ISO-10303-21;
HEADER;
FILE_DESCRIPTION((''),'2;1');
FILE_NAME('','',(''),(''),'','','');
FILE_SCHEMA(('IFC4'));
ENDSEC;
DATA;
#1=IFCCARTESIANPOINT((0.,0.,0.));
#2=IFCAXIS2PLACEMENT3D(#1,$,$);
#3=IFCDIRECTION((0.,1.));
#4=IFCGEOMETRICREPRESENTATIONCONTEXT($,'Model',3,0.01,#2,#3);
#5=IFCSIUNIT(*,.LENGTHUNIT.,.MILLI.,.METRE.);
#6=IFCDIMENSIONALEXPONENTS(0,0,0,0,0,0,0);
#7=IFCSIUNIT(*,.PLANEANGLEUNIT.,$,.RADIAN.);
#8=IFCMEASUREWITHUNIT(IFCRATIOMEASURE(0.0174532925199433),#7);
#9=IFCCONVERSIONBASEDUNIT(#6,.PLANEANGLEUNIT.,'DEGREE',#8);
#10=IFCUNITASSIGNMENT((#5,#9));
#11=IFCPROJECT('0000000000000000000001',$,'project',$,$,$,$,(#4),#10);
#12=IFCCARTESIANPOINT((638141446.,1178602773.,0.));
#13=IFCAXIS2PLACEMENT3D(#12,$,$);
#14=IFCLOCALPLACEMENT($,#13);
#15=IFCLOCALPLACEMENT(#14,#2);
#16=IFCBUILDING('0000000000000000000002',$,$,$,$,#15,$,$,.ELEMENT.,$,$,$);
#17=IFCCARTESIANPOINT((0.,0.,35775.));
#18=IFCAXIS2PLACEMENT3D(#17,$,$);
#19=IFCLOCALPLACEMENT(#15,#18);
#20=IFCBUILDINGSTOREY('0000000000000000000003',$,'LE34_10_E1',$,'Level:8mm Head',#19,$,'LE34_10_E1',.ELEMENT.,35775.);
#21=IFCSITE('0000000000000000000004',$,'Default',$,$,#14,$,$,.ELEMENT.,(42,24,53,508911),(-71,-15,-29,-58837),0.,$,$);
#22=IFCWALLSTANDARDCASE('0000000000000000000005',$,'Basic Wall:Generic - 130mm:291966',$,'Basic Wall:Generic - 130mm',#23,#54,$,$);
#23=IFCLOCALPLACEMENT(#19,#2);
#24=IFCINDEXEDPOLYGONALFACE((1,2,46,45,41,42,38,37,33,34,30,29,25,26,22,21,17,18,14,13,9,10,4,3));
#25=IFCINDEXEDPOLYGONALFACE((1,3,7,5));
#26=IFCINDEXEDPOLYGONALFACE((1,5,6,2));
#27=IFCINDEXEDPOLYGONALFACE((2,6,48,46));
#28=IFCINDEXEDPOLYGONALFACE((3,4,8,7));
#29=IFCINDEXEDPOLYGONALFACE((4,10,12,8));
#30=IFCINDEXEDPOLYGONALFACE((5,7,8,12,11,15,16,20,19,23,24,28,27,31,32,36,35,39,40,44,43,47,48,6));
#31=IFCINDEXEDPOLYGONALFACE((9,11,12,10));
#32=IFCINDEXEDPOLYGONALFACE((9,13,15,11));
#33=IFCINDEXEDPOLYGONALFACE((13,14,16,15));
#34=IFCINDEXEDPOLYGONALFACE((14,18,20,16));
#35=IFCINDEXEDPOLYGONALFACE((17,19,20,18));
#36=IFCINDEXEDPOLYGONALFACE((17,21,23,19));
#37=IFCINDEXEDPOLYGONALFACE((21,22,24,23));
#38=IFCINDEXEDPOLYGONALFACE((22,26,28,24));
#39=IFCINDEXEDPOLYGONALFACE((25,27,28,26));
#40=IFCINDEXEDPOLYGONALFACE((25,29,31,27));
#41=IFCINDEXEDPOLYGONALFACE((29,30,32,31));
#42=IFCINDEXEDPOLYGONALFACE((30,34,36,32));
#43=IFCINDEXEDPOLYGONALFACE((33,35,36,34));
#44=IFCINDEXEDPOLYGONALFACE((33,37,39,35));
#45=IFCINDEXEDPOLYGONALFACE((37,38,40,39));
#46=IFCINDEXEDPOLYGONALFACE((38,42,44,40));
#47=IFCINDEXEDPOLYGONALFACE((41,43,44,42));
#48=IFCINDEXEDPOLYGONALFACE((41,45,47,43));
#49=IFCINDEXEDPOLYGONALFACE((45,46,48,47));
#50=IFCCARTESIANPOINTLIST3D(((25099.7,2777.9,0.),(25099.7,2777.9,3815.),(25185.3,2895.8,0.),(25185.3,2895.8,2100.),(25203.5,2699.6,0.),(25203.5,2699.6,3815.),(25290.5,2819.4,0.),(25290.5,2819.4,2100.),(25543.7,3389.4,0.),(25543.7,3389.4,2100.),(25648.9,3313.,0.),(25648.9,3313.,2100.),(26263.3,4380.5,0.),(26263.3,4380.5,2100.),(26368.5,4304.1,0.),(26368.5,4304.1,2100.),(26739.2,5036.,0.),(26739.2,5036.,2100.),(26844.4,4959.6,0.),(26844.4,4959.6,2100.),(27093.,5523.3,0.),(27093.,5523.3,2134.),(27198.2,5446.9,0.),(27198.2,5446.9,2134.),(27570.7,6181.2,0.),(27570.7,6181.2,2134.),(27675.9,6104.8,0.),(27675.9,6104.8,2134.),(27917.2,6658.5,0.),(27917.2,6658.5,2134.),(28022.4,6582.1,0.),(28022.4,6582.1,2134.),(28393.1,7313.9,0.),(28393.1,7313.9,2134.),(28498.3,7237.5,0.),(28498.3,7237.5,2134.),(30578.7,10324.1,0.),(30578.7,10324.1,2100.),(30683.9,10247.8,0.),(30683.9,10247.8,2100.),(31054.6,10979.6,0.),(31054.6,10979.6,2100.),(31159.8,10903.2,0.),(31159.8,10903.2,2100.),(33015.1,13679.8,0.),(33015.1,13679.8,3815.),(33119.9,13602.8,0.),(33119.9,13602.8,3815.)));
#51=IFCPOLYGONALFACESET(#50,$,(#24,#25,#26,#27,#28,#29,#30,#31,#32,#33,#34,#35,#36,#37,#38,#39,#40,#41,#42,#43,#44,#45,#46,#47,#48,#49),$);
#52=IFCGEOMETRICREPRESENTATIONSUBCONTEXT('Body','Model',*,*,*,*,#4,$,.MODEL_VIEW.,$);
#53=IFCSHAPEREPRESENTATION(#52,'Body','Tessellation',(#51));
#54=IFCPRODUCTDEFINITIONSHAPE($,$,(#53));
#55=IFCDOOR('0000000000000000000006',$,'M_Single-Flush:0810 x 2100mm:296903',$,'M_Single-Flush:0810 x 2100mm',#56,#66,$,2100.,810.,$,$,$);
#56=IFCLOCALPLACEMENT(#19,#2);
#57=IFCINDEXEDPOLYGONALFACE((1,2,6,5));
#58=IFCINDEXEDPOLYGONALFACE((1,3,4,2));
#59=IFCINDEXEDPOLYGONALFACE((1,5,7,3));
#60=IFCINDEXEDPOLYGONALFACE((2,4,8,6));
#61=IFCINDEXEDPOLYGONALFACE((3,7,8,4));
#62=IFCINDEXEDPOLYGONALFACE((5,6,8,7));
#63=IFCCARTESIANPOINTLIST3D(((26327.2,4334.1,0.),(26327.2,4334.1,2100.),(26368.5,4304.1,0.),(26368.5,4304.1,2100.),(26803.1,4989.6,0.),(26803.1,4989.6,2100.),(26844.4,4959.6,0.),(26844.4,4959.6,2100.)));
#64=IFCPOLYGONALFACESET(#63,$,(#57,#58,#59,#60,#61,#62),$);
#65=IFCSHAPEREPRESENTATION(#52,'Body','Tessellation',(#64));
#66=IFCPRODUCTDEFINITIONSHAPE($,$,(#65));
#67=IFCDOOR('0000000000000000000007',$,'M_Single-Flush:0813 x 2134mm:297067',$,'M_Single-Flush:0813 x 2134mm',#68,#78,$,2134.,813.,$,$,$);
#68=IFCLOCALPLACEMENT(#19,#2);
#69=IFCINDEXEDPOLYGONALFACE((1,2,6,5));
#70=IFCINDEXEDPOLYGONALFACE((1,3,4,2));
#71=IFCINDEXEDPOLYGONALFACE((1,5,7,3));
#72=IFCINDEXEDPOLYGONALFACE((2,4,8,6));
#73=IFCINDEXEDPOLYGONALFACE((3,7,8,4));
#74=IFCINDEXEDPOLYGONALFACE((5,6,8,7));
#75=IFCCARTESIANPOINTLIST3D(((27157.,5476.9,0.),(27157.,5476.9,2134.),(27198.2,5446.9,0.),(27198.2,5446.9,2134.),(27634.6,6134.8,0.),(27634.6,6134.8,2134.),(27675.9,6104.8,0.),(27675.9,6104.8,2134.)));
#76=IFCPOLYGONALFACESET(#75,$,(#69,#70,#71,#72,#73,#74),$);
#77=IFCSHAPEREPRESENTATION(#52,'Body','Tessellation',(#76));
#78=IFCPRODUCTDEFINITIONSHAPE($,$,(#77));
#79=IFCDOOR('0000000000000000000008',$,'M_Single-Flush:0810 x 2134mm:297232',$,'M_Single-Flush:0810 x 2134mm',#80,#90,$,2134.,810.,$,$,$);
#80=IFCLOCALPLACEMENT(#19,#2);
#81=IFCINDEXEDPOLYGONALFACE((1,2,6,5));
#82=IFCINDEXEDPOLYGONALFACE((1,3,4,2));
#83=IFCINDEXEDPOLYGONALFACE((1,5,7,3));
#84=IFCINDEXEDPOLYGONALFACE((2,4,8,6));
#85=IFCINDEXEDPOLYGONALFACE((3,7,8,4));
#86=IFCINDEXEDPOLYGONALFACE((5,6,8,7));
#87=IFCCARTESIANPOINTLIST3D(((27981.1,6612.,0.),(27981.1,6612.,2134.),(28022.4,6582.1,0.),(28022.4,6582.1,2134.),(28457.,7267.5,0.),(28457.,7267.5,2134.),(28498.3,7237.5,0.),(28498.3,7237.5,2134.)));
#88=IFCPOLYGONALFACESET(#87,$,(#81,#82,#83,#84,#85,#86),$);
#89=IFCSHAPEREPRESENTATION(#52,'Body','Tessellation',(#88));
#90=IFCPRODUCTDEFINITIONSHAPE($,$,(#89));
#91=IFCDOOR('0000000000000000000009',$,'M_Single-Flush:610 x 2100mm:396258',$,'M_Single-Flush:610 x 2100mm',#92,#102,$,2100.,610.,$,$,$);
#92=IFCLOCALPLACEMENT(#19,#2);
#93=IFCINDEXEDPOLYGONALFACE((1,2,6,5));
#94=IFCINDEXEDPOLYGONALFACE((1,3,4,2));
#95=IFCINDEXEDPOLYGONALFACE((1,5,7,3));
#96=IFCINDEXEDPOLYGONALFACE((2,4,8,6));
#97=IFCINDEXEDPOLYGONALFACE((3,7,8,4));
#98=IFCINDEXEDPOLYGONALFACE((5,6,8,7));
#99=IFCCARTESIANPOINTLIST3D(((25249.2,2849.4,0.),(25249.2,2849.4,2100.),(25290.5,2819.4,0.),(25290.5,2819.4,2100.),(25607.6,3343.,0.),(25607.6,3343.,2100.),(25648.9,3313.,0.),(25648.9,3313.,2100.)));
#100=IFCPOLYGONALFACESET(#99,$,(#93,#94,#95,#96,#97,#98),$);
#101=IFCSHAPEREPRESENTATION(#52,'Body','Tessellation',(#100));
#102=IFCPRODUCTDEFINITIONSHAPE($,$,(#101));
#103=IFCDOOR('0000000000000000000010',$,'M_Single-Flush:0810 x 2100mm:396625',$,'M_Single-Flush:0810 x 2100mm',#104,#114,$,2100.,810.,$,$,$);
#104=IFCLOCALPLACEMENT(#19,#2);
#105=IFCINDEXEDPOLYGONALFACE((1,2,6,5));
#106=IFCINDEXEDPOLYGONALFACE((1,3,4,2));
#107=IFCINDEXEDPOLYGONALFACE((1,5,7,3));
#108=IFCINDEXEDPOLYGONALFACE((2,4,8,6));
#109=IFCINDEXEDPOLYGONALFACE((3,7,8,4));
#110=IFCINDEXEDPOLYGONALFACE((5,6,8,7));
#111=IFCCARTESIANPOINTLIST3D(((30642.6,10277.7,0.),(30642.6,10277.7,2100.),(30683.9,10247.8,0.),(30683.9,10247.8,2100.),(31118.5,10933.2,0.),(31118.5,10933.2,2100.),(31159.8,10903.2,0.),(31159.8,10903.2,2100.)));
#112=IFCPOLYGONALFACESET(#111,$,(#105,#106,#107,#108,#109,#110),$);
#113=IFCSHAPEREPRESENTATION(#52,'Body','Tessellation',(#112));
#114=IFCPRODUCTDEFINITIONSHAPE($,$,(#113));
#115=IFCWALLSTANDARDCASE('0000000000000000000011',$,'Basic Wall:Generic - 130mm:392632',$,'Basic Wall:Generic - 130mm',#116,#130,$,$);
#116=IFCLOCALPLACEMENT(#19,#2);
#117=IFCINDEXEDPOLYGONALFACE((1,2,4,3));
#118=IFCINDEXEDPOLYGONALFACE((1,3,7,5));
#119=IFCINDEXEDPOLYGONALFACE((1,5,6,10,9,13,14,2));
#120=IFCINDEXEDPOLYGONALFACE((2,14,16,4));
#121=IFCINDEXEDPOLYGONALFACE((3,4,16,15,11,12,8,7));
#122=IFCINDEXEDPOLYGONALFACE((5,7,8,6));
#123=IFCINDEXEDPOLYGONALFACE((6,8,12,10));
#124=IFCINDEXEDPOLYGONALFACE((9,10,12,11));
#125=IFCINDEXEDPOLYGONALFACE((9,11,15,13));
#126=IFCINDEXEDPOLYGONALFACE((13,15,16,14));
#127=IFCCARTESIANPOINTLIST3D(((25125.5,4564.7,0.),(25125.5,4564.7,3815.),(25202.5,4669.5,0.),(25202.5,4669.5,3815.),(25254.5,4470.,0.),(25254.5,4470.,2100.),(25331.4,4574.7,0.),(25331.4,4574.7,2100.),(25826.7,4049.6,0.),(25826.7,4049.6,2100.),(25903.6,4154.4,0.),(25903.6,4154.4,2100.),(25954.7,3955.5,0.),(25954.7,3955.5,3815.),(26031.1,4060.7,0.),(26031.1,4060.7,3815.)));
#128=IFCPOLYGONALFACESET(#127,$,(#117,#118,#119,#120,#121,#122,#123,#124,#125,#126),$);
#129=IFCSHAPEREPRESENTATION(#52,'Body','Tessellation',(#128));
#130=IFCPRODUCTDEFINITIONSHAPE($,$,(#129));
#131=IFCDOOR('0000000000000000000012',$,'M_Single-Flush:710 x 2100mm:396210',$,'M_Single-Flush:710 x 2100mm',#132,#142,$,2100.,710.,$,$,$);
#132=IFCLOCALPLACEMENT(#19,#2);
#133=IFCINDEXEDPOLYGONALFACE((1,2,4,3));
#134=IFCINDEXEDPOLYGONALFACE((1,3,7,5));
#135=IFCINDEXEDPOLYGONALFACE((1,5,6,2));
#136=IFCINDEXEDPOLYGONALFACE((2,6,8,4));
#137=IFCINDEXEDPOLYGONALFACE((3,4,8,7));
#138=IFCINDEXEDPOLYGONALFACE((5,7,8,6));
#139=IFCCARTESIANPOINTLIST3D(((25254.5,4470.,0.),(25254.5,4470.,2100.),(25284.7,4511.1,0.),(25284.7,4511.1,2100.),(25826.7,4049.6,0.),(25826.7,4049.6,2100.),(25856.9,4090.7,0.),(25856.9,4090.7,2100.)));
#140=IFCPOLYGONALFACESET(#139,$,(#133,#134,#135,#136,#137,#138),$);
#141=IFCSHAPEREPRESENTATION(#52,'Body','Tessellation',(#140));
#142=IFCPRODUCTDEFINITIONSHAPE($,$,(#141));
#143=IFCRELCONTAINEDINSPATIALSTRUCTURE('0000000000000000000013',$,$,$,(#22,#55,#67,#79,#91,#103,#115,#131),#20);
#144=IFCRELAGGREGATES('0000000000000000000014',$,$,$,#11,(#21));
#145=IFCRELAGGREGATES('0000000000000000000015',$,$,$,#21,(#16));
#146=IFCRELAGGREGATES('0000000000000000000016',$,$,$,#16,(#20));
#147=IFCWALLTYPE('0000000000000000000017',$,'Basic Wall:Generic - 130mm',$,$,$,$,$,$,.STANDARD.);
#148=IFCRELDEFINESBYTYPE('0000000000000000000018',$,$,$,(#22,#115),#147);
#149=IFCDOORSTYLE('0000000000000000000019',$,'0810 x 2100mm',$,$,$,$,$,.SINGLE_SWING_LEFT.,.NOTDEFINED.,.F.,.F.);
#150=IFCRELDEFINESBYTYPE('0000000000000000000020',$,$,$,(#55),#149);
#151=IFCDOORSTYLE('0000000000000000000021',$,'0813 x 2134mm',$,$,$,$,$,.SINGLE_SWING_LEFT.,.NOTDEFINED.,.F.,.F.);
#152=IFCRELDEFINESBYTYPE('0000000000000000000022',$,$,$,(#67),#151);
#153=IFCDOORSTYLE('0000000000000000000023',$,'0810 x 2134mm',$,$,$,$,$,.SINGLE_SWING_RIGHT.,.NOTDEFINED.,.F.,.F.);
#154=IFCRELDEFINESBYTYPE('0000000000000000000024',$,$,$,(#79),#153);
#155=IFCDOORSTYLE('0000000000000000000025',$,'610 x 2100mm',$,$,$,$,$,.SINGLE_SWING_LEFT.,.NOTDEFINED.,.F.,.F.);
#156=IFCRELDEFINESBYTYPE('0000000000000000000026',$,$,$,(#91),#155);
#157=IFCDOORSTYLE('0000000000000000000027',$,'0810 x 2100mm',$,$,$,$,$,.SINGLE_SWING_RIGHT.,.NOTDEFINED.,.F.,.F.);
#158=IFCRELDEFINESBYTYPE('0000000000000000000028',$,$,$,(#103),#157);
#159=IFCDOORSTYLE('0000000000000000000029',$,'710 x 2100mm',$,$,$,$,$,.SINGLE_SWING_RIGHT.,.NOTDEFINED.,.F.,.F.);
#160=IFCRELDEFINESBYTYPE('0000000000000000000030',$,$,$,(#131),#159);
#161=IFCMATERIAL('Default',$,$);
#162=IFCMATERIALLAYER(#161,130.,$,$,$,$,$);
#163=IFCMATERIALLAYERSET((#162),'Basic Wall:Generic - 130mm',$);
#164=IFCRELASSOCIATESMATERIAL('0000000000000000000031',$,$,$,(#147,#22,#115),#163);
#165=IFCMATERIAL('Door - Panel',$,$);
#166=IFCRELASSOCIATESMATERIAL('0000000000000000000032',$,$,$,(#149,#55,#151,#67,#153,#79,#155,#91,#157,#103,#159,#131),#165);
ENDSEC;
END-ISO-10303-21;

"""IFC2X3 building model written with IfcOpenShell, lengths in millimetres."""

from ifc_helpers import new_model, entity, si_unit, converted_unit, direction, frame, frame_2d, origin, place, context, subcontext, project, spatial, polyline, rectangle, outline, extrude, source, transform, mapped, material, layer, layer_set, layer_usage, type_object, type_shapes, element, fill, save


model = new_model("IFC2X3")

# Units and contexts
model_context = context("Model", 3, precision=0.01, world=origin(), true_north=direction((0.0, 1.0)))
body_context = subcontext(model_context, "Body", "Model", "MODEL_VIEW")
ifc_project = project(units=[si_unit("LENGTHUNIT", "METRE", prefix="MILLI"), converted_unit("PLANEANGLEUNIT", "DEGREE", entity("IfcRatioMeasure", 0.0174532925199433), si_unit("PLANEANGLEUNIT", "RADIAN"), dimensions=[0, 0, 0, 0, 0, 0, 0])], contexts=[model_context])

# Site, building, storey
site_placement = place(None, frame((638141446.0, 1178602773.0, 0.0)))
site = spatial("IfcSite", under=ifc_project, at=site_placement, Name="Default", CompositionType="ELEMENT", RefLatitude=(42, 24, 53, 508911), RefLongitude=(-71, -15, -29, -58837), RefElevation=0.0)
building_placement = place(site_placement, origin())
building = spatial("IfcBuilding", under=site, at=building_placement, CompositionType="ELEMENT")
storey_placement = place(building_placement, frame((0.0, 0.0, 35775.0)))
storey = spatial("IfcBuildingStorey", under=building, at=storey_placement, Name="LE34_10_E1", ObjectType="Level:8mm Head", LongName="LE34_10_E1", CompositionType="ELEMENT", Elevation=35775.0)

# Shared definitions
ifc_material_1 = material(Name="Default")

# Wall, openings, doors
ifc_layer_1 = layer(ifc_material_1, 130.0)
ifc_layer_set_1 = layer_set([ifc_layer_1], Name="Basic Wall:Generic - 130mm")
ifc_layer_usage_1 = layer_usage(ifc_layer_set_1, "AXIS2", "NEGATIVE", 65.0)
wall_type_1 = type_object("IfcWallType", Name="Basic Wall:Generic - 130mm", PredefinedType="STANDARD", material=ifc_layer_set_1)
wall_1_placement = place(storey_placement, frame((25150.9, 2737.7, 0.0), z_axis=(0.0, 0.0, 1.0), x_axis=(0.587528, 0.809204, 0.0)))
wall_1 = element("IfcWallStandardCase", 1, at=wall_1_placement, inside=storey, type_object=wall_type_1, material=ifc_layer_usage_1, Name="Basic Wall:Generic - 130mm:291966", ObjectType="Basic Wall:Generic - 130mm", context=body_context, shape_type="SweptSolid", body=[
    extrude(outline(polyline([(0.0, -65.0), (935.1, -65.0), (1195.1, -65.0), (3014.7, -65.0), (3134.7, -65.0), (4466.6, -65.0), (4606.6, -65.0), (13474.0, -65.0), (13474.8, 65.0), (10597.9, 65.0), (10477.9, 65.0), (1587.7, 65.0), (1457.7, 65.0), (2.4, 65.0), (0.0, -65.0)])), origin(), (0.0, 0.0, 1.0), 3815.0),
])
opening_1_placement = place(wall_1_placement, frame((2792.9, 65.0, 0.0)))
opening_1 = element("IfcOpeningElement", 2, at=opening_1_placement, cuts=wall_1, ObjectType="Opening", context=body_context, shape_type="SweptSolid", body=[
    extrude(rectangle(XDim=810.0, YDim=2100.0, at=frame_2d((1050.0, 405.0), x_axis=(0.0, -1.0))), frame((0.0, 0.0, 0.0), z_axis=(0.0, -1.0, 0.0), x_axis=(0.0, 0.0, 1.0)), (0.0, 0.0, 1.0), 130.0),
])
opening_2_placement = place(wall_1_placement, frame((4208.2, 65.0, 0.0)))
opening_2 = element("IfcOpeningElement", 3, at=opening_2_placement, cuts=wall_1, ObjectType="Opening", context=body_context, shape_type="SweptSolid", body=[
    extrude(rectangle(XDim=813.0, YDim=2134.0, at=frame_2d((1067.0, 406.5), x_axis=(0.0, -1.0))), frame((0.0, 0.0, 0.0), z_axis=(0.0, -1.0, 0.0), x_axis=(0.0, 0.0, 1.0)), (0.0, 0.0, 1.0), 130.0),
])
opening_3_placement = place(wall_1_placement, frame((5607.9, 65.0, 0.0)))
opening_3 = element("IfcOpeningElement", 4, at=opening_3_placement, cuts=wall_1, ObjectType="Opening", context=body_context, shape_type="SweptSolid", body=[
    extrude(rectangle(XDim=810.0, YDim=2134.0, at=frame_2d((1067.0, 405.0), x_axis=(0.0, 1.0))), frame((0.0, 0.0, 0.0), z_axis=(0.0, -1.0, 0.0), x_axis=(0.0, 0.0, 1.0)), (0.0, 0.0, 1.0), 130.0),
])
opening_4_placement = place(wall_1_placement, frame((758.1, 65.0, 0.0)))
opening_4 = element("IfcOpeningElement", 5, at=opening_4_placement, cuts=wall_1, ObjectType="Opening", context=body_context, shape_type="SweptSolid", body=[
    extrude(rectangle(XDim=610.0, YDim=2100.0, at=frame_2d((1050.0, 305.0), x_axis=(0.0, -1.0))), frame((0.0, 0.0, 0.0), z_axis=(0.0, -1.0, 0.0), x_axis=(0.0, 0.0, 1.0)), (0.0, 0.0, 1.0), 130.0),
])
opening_5_placement = place(wall_1_placement, frame((10137.9, 65.0, 0.0)))
opening_5 = element("IfcOpeningElement", 6, at=opening_5_placement, cuts=wall_1, ObjectType="Opening", context=body_context, shape_type="SweptSolid", body=[
    extrude(rectangle(XDim=810.0, YDim=2100.0, at=frame_2d((1050.0, 405.0), x_axis=(0.0, 1.0))), frame((0.0, 0.0, 0.0), z_axis=(0.0, -1.0, 0.0), x_axis=(0.0, 0.0, 1.0)), (0.0, 0.0, 1.0), 130.0),
])
ifc_material_2 = material(Name="Door - Panel")
door_style_1 = type_object("IfcDoorStyle", Name="0810 x 2100mm", ConstructionType="NOTDEFINED", OperationType="SINGLE_SWING_LEFT", ParameterTakesPrecedence=False, Sizeable=False, material=ifc_material_2)
shared_shape_1 = source(origin(), body_context, "Body", "SweptSolid", [
    extrude(rectangle(XDim=810.0, YDim=51.0, at=frame_2d((0.0, 0.0), x_axis=(1.0, 0.0))), frame((405.0, 104.5, 0.0)), (0.0, 0.0, 1.0), 2100.0),
])
type_shapes(door_style_1, [shared_shape_1])
door_1_placement = place(opening_1_placement, frame((0.0, 0.0, 0.0), z_axis=(0.0, 0.0, 1.0), x_axis=(-1.0, 0.0, 0.0)))
door_1 = element("IfcDoor", 7, at=door_1_placement, inside=storey, type_object=door_style_1, material=ifc_material_2, Name="M_Single-Flush:0810 x 2100mm:296903", ObjectType="M_Single-Flush:0810 x 2100mm", OverallHeight=2100.0, OverallWidth=810.0, context=body_context, shape_type="MappedRepresentation", body=[
    mapped(shared_shape_1, transform((0.0, 0.0, 0.0), scale=1.0)),
])
fill(opening_1, door_1)
door_style_2 = type_object("IfcDoorStyle", Name="0813 x 2134mm", ConstructionType="NOTDEFINED", OperationType="SINGLE_SWING_LEFT", ParameterTakesPrecedence=False, Sizeable=False, material=ifc_material_2)
shared_shape_2 = source(origin(), body_context, "Body", "SweptSolid", [
    extrude(rectangle(XDim=813.0, YDim=51.0, at=frame_2d((0.0, 0.0), x_axis=(1.0, 0.0))), frame((406.5, 104.5, 0.0)), (0.0, 0.0, 1.0), 2134.0),
])
type_shapes(door_style_2, [shared_shape_2])
door_2_placement = place(opening_2_placement, frame((0.0, 0.0, 0.0), z_axis=(0.0, 0.0, 1.0), x_axis=(-1.0, 0.0, 0.0)))
door_2 = element("IfcDoor", 8, at=door_2_placement, inside=storey, type_object=door_style_2, material=ifc_material_2, Name="M_Single-Flush:0813 x 2134mm:297067", ObjectType="M_Single-Flush:0813 x 2134mm", OverallHeight=2134.0, OverallWidth=813.0, context=body_context, shape_type="MappedRepresentation", body=[
    mapped(shared_shape_2, transform((0.0, 0.0, 0.0), scale=1.0)),
])
fill(opening_2, door_2)
door_style_3 = type_object("IfcDoorStyle", Name="0810 x 2134mm", ConstructionType="NOTDEFINED", OperationType="SINGLE_SWING_RIGHT", ParameterTakesPrecedence=False, Sizeable=False, material=ifc_material_2)
shared_shape_3 = source(origin(), body_context, "Body", "SweptSolid", [
    extrude(rectangle(XDim=51.0, YDim=810.0, at=frame_2d((0.0, 0.0), x_axis=(1.0, 0.0))), frame((405.0, 104.5, 0.0), z_axis=(0.0, 0.0, 1.0), x_axis=(0.0, 1.0, 0.0)), (0.0, 0.0, 1.0), 2134.0),
])
type_shapes(door_style_3, [shared_shape_3])
door_3_placement = place(opening_3_placement, frame((0.0, 0.0, 0.0), z_axis=(0.0, 0.0, 1.0), x_axis=(-1.0, 0.0, 0.0)))
door_3 = element("IfcDoor", 9, at=door_3_placement, inside=storey, type_object=door_style_3, material=ifc_material_2, Name="M_Single-Flush:0810 x 2134mm:297232", ObjectType="M_Single-Flush:0810 x 2134mm", OverallHeight=2134.0, OverallWidth=810.0, context=body_context, shape_type="MappedRepresentation", body=[
    mapped(shared_shape_3, transform((0.0, 0.0, 0.0), scale=1.0)),
])
fill(opening_3, door_3)
door_style_4 = type_object("IfcDoorStyle", Name="610 x 2100mm", ConstructionType="NOTDEFINED", OperationType="SINGLE_SWING_LEFT", ParameterTakesPrecedence=False, Sizeable=False, material=ifc_material_2)
shared_shape_4 = source(origin(), body_context, "Body", "SweptSolid", [
    extrude(rectangle(XDim=610.0, YDim=51.0, at=frame_2d((0.0, 0.0), x_axis=(1.0, 0.0))), frame((305.0, 104.5, 0.0)), (0.0, 0.0, 1.0), 2100.0),
])
type_shapes(door_style_4, [shared_shape_4])
door_4_placement = place(opening_4_placement, frame((0.0, 0.0, 0.0), z_axis=(0.0, 0.0, 1.0), x_axis=(-1.0, 0.0, 0.0)))
door_4 = element("IfcDoor", 10, at=door_4_placement, inside=storey, type_object=door_style_4, material=ifc_material_2, Name="M_Single-Flush:610 x 2100mm:396258", ObjectType="M_Single-Flush:610 x 2100mm", OverallHeight=2100.0, OverallWidth=610.0, context=body_context, shape_type="MappedRepresentation", body=[
    mapped(shared_shape_4, transform((0.0, 0.0, 0.0), scale=1.0)),
])
fill(opening_4, door_4)
door_style_5 = type_object("IfcDoorStyle", Name="0810 x 2100mm", ConstructionType="NOTDEFINED", OperationType="SINGLE_SWING_RIGHT", ParameterTakesPrecedence=False, Sizeable=False, material=ifc_material_2)
shared_shape_5 = source(origin(), body_context, "Body", "SweptSolid", [
    extrude(rectangle(XDim=51.0, YDim=810.0, at=frame_2d((0.0, 0.0), x_axis=(1.0, 0.0))), frame((405.0, 104.5, 0.0), z_axis=(0.0, 0.0, 1.0), x_axis=(0.0, 1.0, 0.0)), (0.0, 0.0, 1.0), 2100.0),
])
type_shapes(door_style_5, [shared_shape_5])
door_5_placement = place(opening_5_placement, frame((0.0, 0.0, 0.0), z_axis=(0.0, 0.0, 1.0), x_axis=(-1.0, 0.0, 0.0)))
door_5 = element("IfcDoor", 11, at=door_5_placement, inside=storey, type_object=door_style_5, material=ifc_material_2, Name="M_Single-Flush:0810 x 2100mm:396625", ObjectType="M_Single-Flush:0810 x 2100mm", OverallHeight=2100.0, OverallWidth=810.0, context=body_context, shape_type="MappedRepresentation", body=[
    mapped(shared_shape_5, transform((0.0, 0.0, 0.0), scale=1.0)),
])
fill(opening_5, door_5)

# Wall, opening, door
ifc_layer_usage_2 = layer_usage(ifc_layer_set_1, "AXIS2", "NEGATIVE", 65.0)
wall_2_placement = place(storey_placement, frame((25164.0, 4617.1, 0.0), z_axis=(0.0, 0.0, 1.0), x_axis=(0.805916, -0.592029, 0.0)))
wall_2 = element("IfcWallStandardCase", 12, at=wall_2_placement, inside=storey, type_object=wall_type_1, material=ifc_layer_usage_2, Name="Basic Wall:Generic - 130mm:392632", ObjectType="Basic Wall:Generic - 130mm", context=body_context, shape_type="SweptSolid", body=[
    extrude(outline(polyline([(0.0, -65.0), (1028.9, -65.0), (1028.2, 65.0), (0.0, 65.0), (0.0, -65.0)])), origin(), (0.0, 0.0, 1.0), 3815.0),
])
opening_6_placement = place(wall_2_placement, frame((870.0, 65.0, 0.0)))
opening_6 = element("IfcOpeningElement", 13, at=opening_6_placement, cuts=wall_2, ObjectType="Opening", context=body_context, shape_type="SweptSolid", body=[
    extrude(rectangle(XDim=710.0, YDim=2100.0, at=frame_2d((1050.0, 355.0), x_axis=(0.0, 1.0))), frame((0.0, 0.0, 0.0), z_axis=(0.0, -1.0, 0.0), x_axis=(0.0, 0.0, 1.0)), (0.0, 0.0, 1.0), 130.0),
])
door_style_6 = type_object("IfcDoorStyle", Name="710 x 2100mm", ConstructionType="NOTDEFINED", OperationType="SINGLE_SWING_RIGHT", ParameterTakesPrecedence=False, Sizeable=False, material=ifc_material_2)
shared_shape_6 = source(origin(), body_context, "Body", "SweptSolid", [
    extrude(rectangle(XDim=51.0, YDim=710.0, at=frame_2d((0.0, 0.0), x_axis=(1.0, 0.0))), frame((355.0, 104.5, 0.0), z_axis=(0.0, 0.0, 1.0), x_axis=(0.0, 1.0, 0.0)), (0.0, 0.0, 1.0), 2100.0),
])
type_shapes(door_style_6, [shared_shape_6])
door_6_placement = place(opening_6_placement, frame((0.0, 0.0, 0.0), z_axis=(0.0, 0.0, 1.0), x_axis=(-1.0, 0.0, 0.0)))
door_6 = element("IfcDoor", 14, at=door_6_placement, inside=storey, type_object=door_style_6, material=ifc_material_2, Name="M_Single-Flush:710 x 2100mm:396210", ObjectType="M_Single-Flush:710 x 2100mm", OverallHeight=2100.0, OverallWidth=710.0, context=body_context, shape_type="MappedRepresentation", body=[
    mapped(shared_shape_6, transform((0.0, 0.0, 0.0), scale=1.0)),
])
fill(opening_6, door_6)

save(model, "model.ifc")
